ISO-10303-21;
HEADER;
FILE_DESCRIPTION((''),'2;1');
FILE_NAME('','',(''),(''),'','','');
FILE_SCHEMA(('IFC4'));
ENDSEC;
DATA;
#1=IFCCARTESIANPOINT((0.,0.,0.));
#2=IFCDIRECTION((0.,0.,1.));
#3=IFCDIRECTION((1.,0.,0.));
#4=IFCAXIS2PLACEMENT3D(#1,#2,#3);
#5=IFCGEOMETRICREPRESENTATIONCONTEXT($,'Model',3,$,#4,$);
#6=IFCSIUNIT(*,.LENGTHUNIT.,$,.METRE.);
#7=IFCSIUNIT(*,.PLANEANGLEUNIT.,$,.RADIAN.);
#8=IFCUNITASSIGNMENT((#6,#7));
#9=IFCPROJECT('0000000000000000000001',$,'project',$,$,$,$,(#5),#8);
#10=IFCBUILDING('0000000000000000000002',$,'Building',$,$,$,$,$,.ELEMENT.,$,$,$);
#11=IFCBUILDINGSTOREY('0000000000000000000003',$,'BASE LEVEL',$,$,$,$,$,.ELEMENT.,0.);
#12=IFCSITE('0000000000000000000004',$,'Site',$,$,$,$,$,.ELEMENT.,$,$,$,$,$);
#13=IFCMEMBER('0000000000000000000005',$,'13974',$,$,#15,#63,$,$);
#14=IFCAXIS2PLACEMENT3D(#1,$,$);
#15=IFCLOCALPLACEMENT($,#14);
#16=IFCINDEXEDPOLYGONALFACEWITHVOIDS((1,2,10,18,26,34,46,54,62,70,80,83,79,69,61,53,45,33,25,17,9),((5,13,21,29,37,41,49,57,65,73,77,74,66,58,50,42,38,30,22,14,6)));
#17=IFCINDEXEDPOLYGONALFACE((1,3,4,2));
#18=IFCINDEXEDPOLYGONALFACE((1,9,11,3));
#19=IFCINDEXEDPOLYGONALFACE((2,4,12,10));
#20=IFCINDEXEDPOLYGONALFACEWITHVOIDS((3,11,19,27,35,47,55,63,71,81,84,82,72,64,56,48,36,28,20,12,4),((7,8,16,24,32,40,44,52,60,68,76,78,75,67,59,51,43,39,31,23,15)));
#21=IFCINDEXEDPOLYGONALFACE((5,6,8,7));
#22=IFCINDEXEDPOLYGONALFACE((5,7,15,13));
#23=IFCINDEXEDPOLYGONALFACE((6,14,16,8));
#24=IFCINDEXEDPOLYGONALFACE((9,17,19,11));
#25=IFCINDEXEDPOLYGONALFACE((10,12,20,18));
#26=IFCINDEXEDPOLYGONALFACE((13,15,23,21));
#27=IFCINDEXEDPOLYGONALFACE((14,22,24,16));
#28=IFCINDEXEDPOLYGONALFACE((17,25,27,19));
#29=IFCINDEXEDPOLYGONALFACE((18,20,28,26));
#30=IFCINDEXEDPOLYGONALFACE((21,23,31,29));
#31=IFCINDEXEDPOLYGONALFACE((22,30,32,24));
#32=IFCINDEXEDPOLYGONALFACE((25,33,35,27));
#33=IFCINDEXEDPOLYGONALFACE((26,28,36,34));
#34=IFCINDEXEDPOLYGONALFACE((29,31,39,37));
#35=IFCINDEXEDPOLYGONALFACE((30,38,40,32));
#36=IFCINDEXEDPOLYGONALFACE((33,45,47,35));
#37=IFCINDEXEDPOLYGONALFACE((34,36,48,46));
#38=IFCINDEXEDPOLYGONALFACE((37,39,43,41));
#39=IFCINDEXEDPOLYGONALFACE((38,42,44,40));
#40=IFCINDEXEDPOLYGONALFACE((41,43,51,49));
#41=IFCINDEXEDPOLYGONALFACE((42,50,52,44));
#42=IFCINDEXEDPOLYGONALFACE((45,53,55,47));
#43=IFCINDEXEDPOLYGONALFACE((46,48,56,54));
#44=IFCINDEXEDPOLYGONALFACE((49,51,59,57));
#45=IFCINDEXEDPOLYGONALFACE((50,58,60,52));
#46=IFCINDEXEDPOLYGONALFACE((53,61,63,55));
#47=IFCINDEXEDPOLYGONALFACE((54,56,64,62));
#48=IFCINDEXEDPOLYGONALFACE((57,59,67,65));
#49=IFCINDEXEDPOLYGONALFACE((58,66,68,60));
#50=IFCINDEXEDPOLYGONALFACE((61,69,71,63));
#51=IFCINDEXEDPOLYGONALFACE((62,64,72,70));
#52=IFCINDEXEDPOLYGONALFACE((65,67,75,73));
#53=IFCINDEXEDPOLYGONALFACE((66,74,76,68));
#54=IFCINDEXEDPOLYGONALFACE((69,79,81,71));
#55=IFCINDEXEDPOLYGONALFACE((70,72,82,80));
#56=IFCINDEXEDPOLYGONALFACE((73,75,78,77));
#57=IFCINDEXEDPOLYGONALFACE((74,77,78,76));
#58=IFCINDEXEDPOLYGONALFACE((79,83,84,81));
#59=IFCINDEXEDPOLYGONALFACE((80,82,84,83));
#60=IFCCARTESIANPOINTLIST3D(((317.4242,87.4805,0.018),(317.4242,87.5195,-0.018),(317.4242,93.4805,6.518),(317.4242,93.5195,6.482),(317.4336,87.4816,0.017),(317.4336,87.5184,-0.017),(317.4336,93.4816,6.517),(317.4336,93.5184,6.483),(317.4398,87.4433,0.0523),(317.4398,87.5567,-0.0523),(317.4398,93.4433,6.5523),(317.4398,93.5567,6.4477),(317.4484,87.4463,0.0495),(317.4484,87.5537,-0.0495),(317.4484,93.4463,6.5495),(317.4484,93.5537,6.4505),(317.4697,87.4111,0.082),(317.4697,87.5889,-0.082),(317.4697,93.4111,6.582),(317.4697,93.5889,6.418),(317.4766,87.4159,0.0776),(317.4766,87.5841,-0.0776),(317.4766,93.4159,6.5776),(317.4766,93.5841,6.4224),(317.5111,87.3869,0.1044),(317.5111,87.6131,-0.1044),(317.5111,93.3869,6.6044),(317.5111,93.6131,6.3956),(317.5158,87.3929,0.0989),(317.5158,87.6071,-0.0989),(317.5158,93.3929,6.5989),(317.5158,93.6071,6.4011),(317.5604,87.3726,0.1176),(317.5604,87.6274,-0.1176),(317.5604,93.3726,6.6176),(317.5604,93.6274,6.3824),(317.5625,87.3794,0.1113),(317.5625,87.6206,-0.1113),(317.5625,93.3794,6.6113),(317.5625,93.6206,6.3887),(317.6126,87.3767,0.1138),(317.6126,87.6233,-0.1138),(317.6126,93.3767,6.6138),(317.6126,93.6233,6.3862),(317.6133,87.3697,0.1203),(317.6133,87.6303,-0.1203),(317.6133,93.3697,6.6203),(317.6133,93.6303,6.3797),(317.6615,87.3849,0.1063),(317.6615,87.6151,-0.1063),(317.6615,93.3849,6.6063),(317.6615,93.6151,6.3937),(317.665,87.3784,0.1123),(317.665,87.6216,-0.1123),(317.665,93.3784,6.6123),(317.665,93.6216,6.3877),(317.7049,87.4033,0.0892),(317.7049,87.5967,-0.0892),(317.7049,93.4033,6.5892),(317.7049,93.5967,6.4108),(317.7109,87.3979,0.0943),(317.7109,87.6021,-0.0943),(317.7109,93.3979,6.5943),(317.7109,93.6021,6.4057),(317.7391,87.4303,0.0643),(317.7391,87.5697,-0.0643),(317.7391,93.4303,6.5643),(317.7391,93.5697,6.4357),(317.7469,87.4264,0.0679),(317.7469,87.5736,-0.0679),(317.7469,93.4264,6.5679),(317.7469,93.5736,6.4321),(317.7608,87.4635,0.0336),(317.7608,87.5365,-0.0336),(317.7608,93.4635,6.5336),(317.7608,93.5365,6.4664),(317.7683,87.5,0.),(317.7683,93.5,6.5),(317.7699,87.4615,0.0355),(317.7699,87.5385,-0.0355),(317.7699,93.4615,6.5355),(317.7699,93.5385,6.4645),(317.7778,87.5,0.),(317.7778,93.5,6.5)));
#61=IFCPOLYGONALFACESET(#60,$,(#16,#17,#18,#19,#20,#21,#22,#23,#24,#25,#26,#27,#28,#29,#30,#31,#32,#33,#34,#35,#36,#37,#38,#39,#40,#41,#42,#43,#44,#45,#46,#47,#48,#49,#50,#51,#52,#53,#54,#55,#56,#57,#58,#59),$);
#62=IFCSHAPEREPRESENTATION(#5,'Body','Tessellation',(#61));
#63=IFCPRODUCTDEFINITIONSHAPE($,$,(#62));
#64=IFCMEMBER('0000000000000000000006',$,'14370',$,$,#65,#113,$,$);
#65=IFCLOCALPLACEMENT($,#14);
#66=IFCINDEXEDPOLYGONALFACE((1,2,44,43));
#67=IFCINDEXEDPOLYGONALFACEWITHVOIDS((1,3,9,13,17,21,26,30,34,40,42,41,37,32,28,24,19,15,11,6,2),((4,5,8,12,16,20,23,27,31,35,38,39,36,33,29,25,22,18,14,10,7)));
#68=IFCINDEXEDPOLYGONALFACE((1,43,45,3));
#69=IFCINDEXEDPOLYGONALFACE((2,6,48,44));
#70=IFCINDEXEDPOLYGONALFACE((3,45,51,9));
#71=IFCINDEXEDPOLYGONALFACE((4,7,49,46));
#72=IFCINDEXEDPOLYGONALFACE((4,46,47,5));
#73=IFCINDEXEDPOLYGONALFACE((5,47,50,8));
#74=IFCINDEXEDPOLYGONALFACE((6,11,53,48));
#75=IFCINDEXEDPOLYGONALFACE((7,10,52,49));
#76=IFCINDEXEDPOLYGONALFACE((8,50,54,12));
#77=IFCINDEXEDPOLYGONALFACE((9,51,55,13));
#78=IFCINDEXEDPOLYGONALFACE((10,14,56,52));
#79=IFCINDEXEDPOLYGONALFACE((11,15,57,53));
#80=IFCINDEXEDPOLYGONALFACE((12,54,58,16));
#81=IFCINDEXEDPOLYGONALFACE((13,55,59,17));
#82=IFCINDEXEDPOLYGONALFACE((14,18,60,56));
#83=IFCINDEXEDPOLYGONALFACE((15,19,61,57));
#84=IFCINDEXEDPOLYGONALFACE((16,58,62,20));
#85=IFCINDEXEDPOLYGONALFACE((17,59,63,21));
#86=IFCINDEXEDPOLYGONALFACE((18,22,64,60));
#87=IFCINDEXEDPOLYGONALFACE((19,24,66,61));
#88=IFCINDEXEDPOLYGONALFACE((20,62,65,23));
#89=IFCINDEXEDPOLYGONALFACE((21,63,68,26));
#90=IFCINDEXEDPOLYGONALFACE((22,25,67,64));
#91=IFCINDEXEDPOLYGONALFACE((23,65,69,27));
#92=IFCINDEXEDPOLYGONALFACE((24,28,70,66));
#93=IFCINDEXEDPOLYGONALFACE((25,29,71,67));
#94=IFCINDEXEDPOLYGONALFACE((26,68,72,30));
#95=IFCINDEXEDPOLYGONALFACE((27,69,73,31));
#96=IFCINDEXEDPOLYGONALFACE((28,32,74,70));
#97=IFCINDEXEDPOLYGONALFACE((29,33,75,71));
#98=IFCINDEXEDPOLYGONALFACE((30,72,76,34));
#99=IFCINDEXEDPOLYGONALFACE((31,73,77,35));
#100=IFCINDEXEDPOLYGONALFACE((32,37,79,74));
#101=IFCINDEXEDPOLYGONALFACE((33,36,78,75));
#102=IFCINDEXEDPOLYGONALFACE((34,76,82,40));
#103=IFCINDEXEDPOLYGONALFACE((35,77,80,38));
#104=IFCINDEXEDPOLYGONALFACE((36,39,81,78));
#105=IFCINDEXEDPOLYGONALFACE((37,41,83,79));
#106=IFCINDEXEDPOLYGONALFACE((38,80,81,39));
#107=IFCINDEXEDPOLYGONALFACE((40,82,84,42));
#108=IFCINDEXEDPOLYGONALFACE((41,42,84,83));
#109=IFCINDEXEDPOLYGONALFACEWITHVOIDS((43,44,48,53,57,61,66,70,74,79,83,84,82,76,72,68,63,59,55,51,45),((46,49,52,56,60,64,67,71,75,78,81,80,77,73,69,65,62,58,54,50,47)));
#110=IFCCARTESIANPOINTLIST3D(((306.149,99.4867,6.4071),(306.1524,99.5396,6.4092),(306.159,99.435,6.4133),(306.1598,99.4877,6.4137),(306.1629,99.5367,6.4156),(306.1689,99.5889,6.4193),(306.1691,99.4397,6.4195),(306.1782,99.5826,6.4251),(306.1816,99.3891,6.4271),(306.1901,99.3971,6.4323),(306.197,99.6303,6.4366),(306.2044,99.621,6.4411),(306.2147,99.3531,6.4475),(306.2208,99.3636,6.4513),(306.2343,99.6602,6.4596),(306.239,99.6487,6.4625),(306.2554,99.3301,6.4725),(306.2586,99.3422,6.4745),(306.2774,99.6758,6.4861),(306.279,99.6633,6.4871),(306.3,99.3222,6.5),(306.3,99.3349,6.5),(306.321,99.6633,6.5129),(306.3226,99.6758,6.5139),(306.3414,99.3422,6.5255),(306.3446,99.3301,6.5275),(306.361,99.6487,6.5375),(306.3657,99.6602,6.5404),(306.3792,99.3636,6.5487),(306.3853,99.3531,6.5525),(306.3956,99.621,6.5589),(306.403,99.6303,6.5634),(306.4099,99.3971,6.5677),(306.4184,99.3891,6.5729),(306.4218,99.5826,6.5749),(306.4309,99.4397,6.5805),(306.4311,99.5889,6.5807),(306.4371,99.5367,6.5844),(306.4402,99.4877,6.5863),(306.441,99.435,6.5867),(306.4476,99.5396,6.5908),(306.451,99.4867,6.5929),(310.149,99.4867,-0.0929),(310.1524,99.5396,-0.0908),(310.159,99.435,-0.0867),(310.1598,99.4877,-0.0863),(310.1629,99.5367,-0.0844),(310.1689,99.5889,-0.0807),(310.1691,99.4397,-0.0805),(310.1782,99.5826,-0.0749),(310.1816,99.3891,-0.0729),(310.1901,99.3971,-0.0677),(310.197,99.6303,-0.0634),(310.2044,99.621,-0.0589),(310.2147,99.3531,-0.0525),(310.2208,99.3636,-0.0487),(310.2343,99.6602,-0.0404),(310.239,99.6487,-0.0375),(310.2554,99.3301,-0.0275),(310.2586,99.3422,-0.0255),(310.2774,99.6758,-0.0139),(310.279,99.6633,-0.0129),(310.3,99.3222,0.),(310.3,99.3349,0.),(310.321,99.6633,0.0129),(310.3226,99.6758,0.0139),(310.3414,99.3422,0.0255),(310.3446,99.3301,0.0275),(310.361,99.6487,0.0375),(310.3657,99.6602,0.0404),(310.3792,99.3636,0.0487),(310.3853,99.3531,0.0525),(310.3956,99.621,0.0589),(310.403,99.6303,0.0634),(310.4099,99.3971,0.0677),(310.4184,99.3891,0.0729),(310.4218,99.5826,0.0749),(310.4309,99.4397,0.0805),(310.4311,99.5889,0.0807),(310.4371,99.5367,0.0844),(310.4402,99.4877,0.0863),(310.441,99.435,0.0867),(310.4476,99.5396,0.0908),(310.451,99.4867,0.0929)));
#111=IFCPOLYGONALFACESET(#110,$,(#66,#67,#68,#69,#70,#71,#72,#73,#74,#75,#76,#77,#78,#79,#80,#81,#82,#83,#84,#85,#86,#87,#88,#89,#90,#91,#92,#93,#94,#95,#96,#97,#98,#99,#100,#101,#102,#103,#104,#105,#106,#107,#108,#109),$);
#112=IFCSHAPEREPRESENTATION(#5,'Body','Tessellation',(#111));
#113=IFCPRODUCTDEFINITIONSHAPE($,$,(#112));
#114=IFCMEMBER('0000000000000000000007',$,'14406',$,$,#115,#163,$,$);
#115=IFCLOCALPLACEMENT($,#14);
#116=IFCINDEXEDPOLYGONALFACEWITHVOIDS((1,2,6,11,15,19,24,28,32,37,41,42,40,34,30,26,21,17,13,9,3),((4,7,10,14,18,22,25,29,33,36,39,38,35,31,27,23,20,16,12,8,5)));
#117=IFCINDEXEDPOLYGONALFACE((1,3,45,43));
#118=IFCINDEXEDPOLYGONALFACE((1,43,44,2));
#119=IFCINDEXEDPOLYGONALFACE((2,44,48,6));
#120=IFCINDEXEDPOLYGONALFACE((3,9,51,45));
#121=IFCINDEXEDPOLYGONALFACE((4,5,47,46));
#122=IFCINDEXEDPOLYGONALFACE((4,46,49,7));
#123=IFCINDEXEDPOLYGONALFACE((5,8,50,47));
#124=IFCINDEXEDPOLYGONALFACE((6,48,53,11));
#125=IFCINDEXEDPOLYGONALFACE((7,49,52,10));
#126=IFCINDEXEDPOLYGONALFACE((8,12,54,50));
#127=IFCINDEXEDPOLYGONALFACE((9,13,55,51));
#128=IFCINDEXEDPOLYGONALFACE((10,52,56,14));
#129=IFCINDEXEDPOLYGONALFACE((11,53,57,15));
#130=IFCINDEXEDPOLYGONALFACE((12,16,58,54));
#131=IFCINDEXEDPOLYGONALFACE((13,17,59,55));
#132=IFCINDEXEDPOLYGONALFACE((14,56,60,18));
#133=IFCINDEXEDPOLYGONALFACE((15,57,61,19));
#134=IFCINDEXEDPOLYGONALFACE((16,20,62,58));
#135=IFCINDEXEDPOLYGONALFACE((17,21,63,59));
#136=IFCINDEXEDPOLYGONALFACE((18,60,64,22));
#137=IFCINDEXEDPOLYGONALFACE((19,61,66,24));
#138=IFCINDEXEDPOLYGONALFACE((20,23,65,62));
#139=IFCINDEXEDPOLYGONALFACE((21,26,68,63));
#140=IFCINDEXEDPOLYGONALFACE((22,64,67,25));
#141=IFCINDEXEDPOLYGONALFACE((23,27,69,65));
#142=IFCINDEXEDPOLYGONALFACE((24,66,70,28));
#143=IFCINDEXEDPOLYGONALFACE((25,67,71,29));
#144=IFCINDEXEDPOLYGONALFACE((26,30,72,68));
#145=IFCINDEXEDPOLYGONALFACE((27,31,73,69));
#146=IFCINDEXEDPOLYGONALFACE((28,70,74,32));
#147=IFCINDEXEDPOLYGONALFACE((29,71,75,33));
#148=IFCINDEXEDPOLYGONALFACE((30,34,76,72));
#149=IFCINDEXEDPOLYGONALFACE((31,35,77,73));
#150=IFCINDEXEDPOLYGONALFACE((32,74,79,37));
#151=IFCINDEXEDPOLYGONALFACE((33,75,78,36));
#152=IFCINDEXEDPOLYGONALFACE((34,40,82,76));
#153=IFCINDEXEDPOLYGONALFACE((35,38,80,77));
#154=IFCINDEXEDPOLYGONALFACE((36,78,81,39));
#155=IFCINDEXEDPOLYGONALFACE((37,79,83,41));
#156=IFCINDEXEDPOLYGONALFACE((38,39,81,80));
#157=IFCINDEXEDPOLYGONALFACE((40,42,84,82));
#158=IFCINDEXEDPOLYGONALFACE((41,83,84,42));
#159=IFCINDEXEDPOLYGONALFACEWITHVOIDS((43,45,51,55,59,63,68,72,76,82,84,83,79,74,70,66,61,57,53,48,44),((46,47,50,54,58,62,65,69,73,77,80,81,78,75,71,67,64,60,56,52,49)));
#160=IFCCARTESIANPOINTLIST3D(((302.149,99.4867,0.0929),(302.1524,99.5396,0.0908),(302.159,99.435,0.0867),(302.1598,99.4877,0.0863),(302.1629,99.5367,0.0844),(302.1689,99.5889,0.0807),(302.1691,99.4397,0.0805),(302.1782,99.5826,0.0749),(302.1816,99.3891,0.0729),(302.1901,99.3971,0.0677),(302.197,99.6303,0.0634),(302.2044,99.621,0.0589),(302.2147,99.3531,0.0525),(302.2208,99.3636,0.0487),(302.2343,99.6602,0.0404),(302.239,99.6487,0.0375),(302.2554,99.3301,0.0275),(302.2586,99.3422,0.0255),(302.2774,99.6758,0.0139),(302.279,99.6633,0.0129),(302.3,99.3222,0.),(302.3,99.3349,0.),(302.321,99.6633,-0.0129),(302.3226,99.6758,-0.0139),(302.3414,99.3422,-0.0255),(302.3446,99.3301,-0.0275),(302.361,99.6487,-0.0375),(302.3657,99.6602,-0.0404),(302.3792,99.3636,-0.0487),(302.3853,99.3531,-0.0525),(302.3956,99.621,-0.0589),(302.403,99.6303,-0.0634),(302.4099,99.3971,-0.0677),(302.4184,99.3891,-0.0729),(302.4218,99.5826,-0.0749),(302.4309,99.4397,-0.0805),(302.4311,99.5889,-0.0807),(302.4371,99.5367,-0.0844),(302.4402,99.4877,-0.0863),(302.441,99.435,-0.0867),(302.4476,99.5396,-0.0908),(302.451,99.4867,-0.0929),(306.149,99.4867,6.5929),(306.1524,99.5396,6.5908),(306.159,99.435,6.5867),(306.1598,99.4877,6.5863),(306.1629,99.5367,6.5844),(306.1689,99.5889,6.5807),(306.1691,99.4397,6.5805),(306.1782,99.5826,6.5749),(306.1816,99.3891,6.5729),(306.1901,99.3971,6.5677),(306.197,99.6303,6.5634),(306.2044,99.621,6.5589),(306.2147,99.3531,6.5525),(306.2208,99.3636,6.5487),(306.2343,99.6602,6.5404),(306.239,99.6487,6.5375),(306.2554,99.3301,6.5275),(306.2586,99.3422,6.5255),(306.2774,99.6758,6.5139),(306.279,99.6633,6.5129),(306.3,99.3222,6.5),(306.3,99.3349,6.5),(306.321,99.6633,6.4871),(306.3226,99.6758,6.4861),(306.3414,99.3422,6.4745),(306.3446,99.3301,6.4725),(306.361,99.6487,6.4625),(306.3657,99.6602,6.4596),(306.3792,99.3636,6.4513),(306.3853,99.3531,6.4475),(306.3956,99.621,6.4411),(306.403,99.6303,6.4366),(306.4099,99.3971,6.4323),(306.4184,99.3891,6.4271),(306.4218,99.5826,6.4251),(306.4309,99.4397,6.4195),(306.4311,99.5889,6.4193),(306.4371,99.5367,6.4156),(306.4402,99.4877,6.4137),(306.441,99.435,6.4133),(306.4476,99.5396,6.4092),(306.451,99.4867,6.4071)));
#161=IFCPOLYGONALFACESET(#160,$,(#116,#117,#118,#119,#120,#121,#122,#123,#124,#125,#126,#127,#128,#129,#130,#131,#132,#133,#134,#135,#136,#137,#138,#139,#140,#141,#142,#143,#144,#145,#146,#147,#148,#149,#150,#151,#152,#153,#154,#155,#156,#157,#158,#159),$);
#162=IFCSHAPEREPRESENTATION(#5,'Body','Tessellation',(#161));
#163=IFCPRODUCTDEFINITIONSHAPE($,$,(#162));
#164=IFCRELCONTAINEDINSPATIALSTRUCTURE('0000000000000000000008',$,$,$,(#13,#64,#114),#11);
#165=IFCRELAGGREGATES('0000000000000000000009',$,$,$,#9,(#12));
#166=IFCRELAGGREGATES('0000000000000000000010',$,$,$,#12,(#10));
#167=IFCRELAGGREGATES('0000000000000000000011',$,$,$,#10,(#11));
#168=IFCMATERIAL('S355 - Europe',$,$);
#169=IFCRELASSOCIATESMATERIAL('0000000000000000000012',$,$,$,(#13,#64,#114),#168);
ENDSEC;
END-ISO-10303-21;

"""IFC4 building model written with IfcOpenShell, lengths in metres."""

from ifc_helpers import new_model, si_unit, frame, origin_with_axes, origin_2d_with_axis, place, context, project, spatial, hollow_circle, extrude, material, material_profile, profile_set, profile_usage, element, save


model = new_model("IFC4")

# Units and contexts
model_context = context("Model", 3, world=origin_with_axes())
ifc_project = project(units=[si_unit("LENGTHUNIT", "METRE"), si_unit("PLANEANGLEUNIT", "RADIAN")], contexts=[model_context])

# Site, building, storey
site = spatial("IfcSite", under=ifc_project, Name="Site", CompositionType="ELEMENT")
building = spatial("IfcBuilding", under=site, Name="Building", CompositionType="ELEMENT")
storey = spatial("IfcBuildingStorey", under=building, Name="BASE LEVEL", CompositionType="ELEMENT", Elevation=0.0)

# Shared definitions
ifc_material = material(Name="S355 - Europe")

# Members
ifc_material_profile_1 = material_profile(ifc_material, hollow_circle(Radius=0.1778, WallThickness=0.0095, at=origin_2d_with_axis()))
ifc_profile_set_1 = profile_set([ifc_material_profile_1])
ifc_profile_usage_1 = profile_usage(ifc_profile_set_1, cardinal=10)
member_1_placement = place(None, frame((317.6, 93.5, 6.5), z_axis=(0.0, -0.67828, -0.734803), x_axis=(1.0, 0.0, 0.0)))
element("IfcMember", 1, at=member_1_placement, inside=storey, material=ifc_profile_usage_1, Name="13974", context=model_context, shape_type="SweptSolid", body=[
    extrude(hollow_circle(Radius=0.1778, WallThickness=0.0095, at=origin_2d_with_axis()), origin_with_axes(), (0.0, 0.0, 1.0), 8.8459),
])
ifc_material_profile_2 = material_profile(ifc_material, hollow_circle(Radius=0.1778, WallThickness=0.0127, at=origin_2d_with_axis()))
ifc_profile_set_2 = profile_set([ifc_material_profile_2])
ifc_profile_usage_2 = profile_usage(ifc_profile_set_2, cardinal=10)
member_2_placement = place(None, frame((310.3, 99.5, 0.0), z_axis=(-0.524097, 0.0, 0.851658), x_axis=(0.0, -1.0, 0.0)))
element("IfcMember", 2, at=member_2_placement, inside=storey, material=ifc_profile_usage_2, Name="14370", context=model_context, shape_type="SweptSolid", body=[
    extrude(hollow_circle(Radius=0.1778, WallThickness=0.0127, at=origin_2d_with_axis()), origin_with_axes(), (0.0, 0.0, 1.0), 7.6322),
])
ifc_material_profile_3 = material_profile(ifc_material, hollow_circle(Radius=0.1778, WallThickness=0.0127, at=origin_2d_with_axis()))
ifc_profile_set_3 = profile_set([ifc_material_profile_3])
ifc_profile_usage_3 = profile_usage(ifc_profile_set_3, cardinal=10)
member_3_placement = place(None, frame((306.3, 99.5, 6.5), z_axis=(-0.524097, 0.0, -0.851658), x_axis=(0.0, -1.0, 0.0)))
element("IfcMember", 3, at=member_3_placement, inside=storey, material=ifc_profile_usage_3, Name="14406", context=model_context, shape_type="SweptSolid", body=[
    extrude(hollow_circle(Radius=0.1778, WallThickness=0.0127, at=origin_2d_with_axis()), origin_with_axes(), (0.0, 0.0, 1.0), 7.6322),
])

save(model, "model.ifc")
